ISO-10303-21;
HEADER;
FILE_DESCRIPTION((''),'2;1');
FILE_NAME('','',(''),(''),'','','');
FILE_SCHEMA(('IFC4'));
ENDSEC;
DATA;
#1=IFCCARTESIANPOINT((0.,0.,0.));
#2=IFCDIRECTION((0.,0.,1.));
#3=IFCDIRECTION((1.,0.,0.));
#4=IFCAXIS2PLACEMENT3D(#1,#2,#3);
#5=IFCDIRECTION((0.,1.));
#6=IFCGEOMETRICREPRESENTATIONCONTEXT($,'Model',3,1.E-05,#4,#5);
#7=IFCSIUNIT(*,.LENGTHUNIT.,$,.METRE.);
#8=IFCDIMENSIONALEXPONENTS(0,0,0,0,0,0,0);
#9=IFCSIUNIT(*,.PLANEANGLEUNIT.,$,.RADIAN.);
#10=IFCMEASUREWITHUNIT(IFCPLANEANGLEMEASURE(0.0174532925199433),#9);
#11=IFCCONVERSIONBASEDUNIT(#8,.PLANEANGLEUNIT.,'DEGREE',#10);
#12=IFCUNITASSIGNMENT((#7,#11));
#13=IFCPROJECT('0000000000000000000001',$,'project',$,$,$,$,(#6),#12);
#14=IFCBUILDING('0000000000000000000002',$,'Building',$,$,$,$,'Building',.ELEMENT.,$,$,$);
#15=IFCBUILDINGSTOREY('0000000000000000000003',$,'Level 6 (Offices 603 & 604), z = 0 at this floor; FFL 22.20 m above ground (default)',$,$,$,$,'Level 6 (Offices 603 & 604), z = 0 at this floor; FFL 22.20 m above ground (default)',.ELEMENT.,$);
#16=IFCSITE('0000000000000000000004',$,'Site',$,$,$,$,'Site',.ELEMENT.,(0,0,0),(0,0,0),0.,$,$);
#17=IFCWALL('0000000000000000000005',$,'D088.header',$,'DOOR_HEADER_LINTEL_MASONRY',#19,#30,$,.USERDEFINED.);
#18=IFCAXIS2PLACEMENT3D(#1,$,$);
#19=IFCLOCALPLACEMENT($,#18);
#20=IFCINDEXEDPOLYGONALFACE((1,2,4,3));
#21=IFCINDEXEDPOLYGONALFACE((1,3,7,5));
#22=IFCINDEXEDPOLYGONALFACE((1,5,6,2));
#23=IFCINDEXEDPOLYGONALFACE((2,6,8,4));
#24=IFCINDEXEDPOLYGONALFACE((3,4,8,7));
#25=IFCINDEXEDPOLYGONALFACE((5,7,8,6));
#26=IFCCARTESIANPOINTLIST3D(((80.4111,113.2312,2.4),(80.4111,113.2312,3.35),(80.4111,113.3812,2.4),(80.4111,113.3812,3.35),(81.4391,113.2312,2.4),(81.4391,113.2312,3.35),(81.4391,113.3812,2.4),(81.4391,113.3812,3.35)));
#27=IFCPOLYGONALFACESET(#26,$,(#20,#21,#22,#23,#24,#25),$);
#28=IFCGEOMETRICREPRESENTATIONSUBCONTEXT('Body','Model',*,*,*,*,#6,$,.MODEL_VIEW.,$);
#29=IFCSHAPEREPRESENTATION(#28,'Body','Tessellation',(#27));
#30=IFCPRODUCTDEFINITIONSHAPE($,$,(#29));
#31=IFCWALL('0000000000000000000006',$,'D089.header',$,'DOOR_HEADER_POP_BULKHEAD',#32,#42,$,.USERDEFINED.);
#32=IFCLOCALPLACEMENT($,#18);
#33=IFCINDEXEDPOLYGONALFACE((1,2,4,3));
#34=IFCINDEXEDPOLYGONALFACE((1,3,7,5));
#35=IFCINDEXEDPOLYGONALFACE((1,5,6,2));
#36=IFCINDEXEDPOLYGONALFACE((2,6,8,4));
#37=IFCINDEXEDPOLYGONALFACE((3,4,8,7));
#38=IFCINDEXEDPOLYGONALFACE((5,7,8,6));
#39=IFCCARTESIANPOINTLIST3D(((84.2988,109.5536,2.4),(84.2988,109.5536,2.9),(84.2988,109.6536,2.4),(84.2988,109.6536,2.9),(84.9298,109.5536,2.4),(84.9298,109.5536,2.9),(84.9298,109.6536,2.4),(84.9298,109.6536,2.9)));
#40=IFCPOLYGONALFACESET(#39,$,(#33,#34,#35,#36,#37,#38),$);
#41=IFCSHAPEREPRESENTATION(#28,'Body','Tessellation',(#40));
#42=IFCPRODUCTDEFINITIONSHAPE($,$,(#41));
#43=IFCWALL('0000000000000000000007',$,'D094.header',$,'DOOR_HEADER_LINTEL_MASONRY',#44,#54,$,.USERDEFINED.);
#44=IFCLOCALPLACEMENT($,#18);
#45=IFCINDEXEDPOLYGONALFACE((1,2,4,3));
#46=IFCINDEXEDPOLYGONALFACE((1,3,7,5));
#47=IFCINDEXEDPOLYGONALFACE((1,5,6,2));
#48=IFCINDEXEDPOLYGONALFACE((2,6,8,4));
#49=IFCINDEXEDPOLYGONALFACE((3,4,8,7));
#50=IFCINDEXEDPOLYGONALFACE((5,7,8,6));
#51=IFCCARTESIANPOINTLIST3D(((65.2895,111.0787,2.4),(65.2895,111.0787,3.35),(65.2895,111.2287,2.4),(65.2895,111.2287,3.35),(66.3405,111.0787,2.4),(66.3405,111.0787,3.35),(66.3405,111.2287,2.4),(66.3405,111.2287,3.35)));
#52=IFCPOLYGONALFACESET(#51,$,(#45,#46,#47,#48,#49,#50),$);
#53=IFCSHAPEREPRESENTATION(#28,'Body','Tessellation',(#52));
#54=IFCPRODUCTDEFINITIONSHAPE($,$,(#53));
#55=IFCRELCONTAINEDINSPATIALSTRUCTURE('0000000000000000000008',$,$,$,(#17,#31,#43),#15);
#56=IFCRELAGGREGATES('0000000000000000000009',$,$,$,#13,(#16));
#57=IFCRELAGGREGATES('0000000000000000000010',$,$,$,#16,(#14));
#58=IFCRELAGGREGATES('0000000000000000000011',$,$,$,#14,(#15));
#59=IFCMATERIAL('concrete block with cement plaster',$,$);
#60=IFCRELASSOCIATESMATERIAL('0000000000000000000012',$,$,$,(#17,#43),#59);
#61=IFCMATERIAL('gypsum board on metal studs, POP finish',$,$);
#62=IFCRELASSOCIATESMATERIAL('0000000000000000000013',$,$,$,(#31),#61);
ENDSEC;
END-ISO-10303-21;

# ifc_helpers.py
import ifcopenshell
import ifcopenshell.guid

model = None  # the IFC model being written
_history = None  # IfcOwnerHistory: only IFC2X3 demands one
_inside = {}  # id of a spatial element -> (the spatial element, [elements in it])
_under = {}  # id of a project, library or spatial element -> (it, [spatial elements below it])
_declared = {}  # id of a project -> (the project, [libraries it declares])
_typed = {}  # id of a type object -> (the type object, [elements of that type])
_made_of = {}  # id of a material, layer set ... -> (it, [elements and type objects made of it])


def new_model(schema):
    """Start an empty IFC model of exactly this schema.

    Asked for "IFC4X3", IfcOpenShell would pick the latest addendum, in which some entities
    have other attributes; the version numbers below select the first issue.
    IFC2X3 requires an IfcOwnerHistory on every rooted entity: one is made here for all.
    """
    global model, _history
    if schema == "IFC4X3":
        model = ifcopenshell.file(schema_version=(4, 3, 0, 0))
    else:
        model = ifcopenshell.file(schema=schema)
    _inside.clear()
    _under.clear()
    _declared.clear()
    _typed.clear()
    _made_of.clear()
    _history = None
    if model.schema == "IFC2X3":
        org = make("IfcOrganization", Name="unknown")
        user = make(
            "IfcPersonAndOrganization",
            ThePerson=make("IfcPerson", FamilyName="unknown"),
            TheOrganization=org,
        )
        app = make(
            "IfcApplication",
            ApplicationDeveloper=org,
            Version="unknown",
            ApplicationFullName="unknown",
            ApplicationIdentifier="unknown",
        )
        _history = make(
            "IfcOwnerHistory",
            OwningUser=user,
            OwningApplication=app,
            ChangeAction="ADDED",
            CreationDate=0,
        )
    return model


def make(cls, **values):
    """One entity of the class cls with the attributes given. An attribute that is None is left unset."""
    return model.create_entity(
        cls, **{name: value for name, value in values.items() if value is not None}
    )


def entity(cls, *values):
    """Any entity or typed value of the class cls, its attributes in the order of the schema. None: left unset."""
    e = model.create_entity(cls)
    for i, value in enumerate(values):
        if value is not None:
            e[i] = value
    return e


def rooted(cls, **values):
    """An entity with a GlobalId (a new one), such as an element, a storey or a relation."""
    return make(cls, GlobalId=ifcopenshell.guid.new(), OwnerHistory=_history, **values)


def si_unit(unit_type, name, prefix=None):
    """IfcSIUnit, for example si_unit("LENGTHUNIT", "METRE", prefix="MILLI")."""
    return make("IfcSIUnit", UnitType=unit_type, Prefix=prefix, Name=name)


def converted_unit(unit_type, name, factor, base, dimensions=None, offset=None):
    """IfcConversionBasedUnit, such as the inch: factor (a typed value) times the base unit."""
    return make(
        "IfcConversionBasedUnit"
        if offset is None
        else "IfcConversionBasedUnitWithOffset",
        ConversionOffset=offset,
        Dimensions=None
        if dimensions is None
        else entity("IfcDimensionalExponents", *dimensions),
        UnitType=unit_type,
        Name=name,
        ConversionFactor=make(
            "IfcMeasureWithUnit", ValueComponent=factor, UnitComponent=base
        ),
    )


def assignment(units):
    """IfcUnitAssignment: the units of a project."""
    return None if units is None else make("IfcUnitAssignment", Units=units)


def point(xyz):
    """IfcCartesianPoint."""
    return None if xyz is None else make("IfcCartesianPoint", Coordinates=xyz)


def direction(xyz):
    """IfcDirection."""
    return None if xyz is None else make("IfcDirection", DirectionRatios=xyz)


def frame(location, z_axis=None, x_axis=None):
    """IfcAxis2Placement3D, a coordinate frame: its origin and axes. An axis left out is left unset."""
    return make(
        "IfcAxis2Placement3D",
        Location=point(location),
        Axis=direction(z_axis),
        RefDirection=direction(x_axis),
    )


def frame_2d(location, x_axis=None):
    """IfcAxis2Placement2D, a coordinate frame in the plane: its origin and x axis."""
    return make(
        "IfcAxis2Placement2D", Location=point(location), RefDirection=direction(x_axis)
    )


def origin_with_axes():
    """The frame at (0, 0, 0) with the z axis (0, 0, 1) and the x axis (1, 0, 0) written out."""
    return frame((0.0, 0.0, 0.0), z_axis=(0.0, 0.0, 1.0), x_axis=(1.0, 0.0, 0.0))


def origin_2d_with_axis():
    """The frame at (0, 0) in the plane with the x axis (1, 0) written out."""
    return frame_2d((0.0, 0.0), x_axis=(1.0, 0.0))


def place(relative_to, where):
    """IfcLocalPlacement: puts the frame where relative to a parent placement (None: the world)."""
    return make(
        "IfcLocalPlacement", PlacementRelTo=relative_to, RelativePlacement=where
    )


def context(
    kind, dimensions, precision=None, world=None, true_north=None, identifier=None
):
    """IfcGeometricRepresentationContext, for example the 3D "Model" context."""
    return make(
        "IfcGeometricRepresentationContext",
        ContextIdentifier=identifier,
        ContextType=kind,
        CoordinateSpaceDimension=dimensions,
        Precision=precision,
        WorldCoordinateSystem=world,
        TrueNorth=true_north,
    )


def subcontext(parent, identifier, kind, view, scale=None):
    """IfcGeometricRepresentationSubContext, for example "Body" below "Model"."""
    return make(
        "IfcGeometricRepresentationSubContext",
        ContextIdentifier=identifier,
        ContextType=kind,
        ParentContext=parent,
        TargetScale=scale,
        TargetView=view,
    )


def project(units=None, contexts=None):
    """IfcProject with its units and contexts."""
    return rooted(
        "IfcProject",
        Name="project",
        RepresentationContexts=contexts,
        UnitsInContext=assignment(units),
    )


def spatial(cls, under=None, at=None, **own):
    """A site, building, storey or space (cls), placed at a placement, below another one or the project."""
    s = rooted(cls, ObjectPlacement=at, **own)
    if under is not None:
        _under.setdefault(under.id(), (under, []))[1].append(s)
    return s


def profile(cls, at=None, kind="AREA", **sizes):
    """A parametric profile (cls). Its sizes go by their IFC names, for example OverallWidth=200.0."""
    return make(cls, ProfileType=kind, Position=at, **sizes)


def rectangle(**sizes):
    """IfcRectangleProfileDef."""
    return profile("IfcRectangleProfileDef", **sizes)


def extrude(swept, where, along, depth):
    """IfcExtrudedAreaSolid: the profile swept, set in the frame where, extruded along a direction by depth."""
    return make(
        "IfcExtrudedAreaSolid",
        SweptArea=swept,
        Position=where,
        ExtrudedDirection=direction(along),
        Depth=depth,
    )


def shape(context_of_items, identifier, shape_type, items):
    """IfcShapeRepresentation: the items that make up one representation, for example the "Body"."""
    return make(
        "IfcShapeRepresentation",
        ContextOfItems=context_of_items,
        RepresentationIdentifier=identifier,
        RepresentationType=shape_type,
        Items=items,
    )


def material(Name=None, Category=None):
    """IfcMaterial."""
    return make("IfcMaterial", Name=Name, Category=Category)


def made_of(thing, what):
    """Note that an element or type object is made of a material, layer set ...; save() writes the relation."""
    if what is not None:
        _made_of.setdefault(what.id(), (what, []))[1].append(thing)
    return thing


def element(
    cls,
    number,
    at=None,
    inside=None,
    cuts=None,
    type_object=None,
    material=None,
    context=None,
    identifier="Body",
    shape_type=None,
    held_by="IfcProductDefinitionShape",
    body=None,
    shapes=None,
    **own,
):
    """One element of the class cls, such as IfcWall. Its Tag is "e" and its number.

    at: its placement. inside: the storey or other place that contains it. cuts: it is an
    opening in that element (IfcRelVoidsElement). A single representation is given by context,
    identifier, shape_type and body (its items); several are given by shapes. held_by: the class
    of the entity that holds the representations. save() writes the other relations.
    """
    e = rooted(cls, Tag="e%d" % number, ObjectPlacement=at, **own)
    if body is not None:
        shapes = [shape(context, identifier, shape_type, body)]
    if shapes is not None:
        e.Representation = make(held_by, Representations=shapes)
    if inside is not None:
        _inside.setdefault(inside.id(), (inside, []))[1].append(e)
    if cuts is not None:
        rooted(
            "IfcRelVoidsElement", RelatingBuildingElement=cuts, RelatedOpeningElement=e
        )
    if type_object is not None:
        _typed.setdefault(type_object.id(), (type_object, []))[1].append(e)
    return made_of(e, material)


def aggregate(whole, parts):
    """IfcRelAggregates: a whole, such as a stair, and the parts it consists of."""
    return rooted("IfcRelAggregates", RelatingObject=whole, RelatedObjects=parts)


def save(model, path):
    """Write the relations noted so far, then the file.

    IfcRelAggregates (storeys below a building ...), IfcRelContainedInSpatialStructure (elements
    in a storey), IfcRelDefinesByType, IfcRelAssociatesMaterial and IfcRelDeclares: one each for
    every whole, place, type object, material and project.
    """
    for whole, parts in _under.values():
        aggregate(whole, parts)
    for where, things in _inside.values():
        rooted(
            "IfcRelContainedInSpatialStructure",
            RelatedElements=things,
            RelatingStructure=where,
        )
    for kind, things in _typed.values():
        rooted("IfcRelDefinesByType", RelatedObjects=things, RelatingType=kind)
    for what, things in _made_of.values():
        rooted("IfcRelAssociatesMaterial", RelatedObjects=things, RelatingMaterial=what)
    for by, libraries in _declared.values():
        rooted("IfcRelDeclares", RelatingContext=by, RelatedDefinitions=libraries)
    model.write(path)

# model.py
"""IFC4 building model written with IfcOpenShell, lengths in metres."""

from ifc_helpers import new_model, entity, si_unit, converted_unit, direction, frame, frame_2d, origin_with_axes, origin_2d_with_axis, place, context, subcontext, project, spatial, rectangle, extrude, material, element, save


model = new_model("IFC4")

# Units and contexts
model_context = context("Model", 3, precision=1e-05, world=origin_with_axes(), true_north=direction((0.0, 1.0)))
body_context = subcontext(model_context, "Body", "Model", "MODEL_VIEW")
ifc_project = project(units=[si_unit("LENGTHUNIT", "METRE"), converted_unit("PLANEANGLEUNIT", "DEGREE", entity("IfcPlaneAngleMeasure", 0.0174532925199433), si_unit("PLANEANGLEUNIT", "RADIAN"), dimensions=[0, 0, 0, 0, 0, 0, 0])], contexts=[model_context])

# Site, building, storey
site = spatial("IfcSite", under=ifc_project, Name="Site", LongName="Site", CompositionType="ELEMENT", RefLatitude=(0, 0, 0), RefLongitude=(0, 0, 0), RefElevation=0.0)
building = spatial("IfcBuilding", under=site, Name="Building", LongName="Building", CompositionType="ELEMENT")
storey = spatial("IfcBuildingStorey", under=building, Name="Level 6 (Offices 603 & 604), z = 0 at this floor; FFL 22.20 m above ground (default)", LongName="Level 6 (Offices 603 & 604), z = 0 at this floor; FFL 22.20 m above ground (default)", CompositionType="ELEMENT")

# Shared definitions
placement = place(None, origin_with_axes())

# Walls
ifc_material_1 = material(Name="gypsum board on metal studs, POP finish")
ifc_material_2 = material(Name="concrete block with cement plaster")
element("IfcWall", 1, at=placement, inside=storey, material=ifc_material_2, Name="D088.header", ObjectType="DOOR_HEADER_LINTEL_MASONRY", PredefinedType="USERDEFINED", context=body_context, shape_type="SweptSolid", body=[
    extrude(rectangle(XDim=1.028, YDim=0.15, at=frame_2d((0.0, 0.0), x_axis=(1.0, 0.0))), frame((80.925, 113.3063, 2.4), z_axis=(0.0, 0.0, 1.0), x_axis=(1.0, 0.0, 0.0)), (0.0, 0.0, 1.0), 0.95),
])
element("IfcWall", 2, at=placement, inside=storey, material=ifc_material_1, Name="D089.header", ObjectType="DOOR_HEADER_POP_BULKHEAD", PredefinedType="USERDEFINED", context=body_context, shape_type="SweptSolid", body=[
    extrude(rectangle(XDim=0.631, YDim=0.1, at=origin_2d_with_axis()), frame((84.6143, 109.6036, 2.4), z_axis=(0.0, 0.0, 1.0), x_axis=(1.0, 0.0, 0.0)), (0.0, 0.0, 1.0), 0.5),
])
element("IfcWall", 3, at=placement, inside=storey, material=ifc_material_2, Name="D094.header", ObjectType="DOOR_HEADER_LINTEL_MASONRY", PredefinedType="USERDEFINED", context=body_context, shape_type="SweptSolid", body=[
    extrude(rectangle(XDim=1.051, YDim=0.15, at=frame_2d((0.0, 0.0), x_axis=(1.0, 0.0))), frame((65.815, 111.1538, 2.4), z_axis=(0.0, 0.0, 1.0), x_axis=(1.0, 0.0, 0.0)), (0.0, 0.0, 1.0), 0.95),
])

save(model, "model.ifc")
